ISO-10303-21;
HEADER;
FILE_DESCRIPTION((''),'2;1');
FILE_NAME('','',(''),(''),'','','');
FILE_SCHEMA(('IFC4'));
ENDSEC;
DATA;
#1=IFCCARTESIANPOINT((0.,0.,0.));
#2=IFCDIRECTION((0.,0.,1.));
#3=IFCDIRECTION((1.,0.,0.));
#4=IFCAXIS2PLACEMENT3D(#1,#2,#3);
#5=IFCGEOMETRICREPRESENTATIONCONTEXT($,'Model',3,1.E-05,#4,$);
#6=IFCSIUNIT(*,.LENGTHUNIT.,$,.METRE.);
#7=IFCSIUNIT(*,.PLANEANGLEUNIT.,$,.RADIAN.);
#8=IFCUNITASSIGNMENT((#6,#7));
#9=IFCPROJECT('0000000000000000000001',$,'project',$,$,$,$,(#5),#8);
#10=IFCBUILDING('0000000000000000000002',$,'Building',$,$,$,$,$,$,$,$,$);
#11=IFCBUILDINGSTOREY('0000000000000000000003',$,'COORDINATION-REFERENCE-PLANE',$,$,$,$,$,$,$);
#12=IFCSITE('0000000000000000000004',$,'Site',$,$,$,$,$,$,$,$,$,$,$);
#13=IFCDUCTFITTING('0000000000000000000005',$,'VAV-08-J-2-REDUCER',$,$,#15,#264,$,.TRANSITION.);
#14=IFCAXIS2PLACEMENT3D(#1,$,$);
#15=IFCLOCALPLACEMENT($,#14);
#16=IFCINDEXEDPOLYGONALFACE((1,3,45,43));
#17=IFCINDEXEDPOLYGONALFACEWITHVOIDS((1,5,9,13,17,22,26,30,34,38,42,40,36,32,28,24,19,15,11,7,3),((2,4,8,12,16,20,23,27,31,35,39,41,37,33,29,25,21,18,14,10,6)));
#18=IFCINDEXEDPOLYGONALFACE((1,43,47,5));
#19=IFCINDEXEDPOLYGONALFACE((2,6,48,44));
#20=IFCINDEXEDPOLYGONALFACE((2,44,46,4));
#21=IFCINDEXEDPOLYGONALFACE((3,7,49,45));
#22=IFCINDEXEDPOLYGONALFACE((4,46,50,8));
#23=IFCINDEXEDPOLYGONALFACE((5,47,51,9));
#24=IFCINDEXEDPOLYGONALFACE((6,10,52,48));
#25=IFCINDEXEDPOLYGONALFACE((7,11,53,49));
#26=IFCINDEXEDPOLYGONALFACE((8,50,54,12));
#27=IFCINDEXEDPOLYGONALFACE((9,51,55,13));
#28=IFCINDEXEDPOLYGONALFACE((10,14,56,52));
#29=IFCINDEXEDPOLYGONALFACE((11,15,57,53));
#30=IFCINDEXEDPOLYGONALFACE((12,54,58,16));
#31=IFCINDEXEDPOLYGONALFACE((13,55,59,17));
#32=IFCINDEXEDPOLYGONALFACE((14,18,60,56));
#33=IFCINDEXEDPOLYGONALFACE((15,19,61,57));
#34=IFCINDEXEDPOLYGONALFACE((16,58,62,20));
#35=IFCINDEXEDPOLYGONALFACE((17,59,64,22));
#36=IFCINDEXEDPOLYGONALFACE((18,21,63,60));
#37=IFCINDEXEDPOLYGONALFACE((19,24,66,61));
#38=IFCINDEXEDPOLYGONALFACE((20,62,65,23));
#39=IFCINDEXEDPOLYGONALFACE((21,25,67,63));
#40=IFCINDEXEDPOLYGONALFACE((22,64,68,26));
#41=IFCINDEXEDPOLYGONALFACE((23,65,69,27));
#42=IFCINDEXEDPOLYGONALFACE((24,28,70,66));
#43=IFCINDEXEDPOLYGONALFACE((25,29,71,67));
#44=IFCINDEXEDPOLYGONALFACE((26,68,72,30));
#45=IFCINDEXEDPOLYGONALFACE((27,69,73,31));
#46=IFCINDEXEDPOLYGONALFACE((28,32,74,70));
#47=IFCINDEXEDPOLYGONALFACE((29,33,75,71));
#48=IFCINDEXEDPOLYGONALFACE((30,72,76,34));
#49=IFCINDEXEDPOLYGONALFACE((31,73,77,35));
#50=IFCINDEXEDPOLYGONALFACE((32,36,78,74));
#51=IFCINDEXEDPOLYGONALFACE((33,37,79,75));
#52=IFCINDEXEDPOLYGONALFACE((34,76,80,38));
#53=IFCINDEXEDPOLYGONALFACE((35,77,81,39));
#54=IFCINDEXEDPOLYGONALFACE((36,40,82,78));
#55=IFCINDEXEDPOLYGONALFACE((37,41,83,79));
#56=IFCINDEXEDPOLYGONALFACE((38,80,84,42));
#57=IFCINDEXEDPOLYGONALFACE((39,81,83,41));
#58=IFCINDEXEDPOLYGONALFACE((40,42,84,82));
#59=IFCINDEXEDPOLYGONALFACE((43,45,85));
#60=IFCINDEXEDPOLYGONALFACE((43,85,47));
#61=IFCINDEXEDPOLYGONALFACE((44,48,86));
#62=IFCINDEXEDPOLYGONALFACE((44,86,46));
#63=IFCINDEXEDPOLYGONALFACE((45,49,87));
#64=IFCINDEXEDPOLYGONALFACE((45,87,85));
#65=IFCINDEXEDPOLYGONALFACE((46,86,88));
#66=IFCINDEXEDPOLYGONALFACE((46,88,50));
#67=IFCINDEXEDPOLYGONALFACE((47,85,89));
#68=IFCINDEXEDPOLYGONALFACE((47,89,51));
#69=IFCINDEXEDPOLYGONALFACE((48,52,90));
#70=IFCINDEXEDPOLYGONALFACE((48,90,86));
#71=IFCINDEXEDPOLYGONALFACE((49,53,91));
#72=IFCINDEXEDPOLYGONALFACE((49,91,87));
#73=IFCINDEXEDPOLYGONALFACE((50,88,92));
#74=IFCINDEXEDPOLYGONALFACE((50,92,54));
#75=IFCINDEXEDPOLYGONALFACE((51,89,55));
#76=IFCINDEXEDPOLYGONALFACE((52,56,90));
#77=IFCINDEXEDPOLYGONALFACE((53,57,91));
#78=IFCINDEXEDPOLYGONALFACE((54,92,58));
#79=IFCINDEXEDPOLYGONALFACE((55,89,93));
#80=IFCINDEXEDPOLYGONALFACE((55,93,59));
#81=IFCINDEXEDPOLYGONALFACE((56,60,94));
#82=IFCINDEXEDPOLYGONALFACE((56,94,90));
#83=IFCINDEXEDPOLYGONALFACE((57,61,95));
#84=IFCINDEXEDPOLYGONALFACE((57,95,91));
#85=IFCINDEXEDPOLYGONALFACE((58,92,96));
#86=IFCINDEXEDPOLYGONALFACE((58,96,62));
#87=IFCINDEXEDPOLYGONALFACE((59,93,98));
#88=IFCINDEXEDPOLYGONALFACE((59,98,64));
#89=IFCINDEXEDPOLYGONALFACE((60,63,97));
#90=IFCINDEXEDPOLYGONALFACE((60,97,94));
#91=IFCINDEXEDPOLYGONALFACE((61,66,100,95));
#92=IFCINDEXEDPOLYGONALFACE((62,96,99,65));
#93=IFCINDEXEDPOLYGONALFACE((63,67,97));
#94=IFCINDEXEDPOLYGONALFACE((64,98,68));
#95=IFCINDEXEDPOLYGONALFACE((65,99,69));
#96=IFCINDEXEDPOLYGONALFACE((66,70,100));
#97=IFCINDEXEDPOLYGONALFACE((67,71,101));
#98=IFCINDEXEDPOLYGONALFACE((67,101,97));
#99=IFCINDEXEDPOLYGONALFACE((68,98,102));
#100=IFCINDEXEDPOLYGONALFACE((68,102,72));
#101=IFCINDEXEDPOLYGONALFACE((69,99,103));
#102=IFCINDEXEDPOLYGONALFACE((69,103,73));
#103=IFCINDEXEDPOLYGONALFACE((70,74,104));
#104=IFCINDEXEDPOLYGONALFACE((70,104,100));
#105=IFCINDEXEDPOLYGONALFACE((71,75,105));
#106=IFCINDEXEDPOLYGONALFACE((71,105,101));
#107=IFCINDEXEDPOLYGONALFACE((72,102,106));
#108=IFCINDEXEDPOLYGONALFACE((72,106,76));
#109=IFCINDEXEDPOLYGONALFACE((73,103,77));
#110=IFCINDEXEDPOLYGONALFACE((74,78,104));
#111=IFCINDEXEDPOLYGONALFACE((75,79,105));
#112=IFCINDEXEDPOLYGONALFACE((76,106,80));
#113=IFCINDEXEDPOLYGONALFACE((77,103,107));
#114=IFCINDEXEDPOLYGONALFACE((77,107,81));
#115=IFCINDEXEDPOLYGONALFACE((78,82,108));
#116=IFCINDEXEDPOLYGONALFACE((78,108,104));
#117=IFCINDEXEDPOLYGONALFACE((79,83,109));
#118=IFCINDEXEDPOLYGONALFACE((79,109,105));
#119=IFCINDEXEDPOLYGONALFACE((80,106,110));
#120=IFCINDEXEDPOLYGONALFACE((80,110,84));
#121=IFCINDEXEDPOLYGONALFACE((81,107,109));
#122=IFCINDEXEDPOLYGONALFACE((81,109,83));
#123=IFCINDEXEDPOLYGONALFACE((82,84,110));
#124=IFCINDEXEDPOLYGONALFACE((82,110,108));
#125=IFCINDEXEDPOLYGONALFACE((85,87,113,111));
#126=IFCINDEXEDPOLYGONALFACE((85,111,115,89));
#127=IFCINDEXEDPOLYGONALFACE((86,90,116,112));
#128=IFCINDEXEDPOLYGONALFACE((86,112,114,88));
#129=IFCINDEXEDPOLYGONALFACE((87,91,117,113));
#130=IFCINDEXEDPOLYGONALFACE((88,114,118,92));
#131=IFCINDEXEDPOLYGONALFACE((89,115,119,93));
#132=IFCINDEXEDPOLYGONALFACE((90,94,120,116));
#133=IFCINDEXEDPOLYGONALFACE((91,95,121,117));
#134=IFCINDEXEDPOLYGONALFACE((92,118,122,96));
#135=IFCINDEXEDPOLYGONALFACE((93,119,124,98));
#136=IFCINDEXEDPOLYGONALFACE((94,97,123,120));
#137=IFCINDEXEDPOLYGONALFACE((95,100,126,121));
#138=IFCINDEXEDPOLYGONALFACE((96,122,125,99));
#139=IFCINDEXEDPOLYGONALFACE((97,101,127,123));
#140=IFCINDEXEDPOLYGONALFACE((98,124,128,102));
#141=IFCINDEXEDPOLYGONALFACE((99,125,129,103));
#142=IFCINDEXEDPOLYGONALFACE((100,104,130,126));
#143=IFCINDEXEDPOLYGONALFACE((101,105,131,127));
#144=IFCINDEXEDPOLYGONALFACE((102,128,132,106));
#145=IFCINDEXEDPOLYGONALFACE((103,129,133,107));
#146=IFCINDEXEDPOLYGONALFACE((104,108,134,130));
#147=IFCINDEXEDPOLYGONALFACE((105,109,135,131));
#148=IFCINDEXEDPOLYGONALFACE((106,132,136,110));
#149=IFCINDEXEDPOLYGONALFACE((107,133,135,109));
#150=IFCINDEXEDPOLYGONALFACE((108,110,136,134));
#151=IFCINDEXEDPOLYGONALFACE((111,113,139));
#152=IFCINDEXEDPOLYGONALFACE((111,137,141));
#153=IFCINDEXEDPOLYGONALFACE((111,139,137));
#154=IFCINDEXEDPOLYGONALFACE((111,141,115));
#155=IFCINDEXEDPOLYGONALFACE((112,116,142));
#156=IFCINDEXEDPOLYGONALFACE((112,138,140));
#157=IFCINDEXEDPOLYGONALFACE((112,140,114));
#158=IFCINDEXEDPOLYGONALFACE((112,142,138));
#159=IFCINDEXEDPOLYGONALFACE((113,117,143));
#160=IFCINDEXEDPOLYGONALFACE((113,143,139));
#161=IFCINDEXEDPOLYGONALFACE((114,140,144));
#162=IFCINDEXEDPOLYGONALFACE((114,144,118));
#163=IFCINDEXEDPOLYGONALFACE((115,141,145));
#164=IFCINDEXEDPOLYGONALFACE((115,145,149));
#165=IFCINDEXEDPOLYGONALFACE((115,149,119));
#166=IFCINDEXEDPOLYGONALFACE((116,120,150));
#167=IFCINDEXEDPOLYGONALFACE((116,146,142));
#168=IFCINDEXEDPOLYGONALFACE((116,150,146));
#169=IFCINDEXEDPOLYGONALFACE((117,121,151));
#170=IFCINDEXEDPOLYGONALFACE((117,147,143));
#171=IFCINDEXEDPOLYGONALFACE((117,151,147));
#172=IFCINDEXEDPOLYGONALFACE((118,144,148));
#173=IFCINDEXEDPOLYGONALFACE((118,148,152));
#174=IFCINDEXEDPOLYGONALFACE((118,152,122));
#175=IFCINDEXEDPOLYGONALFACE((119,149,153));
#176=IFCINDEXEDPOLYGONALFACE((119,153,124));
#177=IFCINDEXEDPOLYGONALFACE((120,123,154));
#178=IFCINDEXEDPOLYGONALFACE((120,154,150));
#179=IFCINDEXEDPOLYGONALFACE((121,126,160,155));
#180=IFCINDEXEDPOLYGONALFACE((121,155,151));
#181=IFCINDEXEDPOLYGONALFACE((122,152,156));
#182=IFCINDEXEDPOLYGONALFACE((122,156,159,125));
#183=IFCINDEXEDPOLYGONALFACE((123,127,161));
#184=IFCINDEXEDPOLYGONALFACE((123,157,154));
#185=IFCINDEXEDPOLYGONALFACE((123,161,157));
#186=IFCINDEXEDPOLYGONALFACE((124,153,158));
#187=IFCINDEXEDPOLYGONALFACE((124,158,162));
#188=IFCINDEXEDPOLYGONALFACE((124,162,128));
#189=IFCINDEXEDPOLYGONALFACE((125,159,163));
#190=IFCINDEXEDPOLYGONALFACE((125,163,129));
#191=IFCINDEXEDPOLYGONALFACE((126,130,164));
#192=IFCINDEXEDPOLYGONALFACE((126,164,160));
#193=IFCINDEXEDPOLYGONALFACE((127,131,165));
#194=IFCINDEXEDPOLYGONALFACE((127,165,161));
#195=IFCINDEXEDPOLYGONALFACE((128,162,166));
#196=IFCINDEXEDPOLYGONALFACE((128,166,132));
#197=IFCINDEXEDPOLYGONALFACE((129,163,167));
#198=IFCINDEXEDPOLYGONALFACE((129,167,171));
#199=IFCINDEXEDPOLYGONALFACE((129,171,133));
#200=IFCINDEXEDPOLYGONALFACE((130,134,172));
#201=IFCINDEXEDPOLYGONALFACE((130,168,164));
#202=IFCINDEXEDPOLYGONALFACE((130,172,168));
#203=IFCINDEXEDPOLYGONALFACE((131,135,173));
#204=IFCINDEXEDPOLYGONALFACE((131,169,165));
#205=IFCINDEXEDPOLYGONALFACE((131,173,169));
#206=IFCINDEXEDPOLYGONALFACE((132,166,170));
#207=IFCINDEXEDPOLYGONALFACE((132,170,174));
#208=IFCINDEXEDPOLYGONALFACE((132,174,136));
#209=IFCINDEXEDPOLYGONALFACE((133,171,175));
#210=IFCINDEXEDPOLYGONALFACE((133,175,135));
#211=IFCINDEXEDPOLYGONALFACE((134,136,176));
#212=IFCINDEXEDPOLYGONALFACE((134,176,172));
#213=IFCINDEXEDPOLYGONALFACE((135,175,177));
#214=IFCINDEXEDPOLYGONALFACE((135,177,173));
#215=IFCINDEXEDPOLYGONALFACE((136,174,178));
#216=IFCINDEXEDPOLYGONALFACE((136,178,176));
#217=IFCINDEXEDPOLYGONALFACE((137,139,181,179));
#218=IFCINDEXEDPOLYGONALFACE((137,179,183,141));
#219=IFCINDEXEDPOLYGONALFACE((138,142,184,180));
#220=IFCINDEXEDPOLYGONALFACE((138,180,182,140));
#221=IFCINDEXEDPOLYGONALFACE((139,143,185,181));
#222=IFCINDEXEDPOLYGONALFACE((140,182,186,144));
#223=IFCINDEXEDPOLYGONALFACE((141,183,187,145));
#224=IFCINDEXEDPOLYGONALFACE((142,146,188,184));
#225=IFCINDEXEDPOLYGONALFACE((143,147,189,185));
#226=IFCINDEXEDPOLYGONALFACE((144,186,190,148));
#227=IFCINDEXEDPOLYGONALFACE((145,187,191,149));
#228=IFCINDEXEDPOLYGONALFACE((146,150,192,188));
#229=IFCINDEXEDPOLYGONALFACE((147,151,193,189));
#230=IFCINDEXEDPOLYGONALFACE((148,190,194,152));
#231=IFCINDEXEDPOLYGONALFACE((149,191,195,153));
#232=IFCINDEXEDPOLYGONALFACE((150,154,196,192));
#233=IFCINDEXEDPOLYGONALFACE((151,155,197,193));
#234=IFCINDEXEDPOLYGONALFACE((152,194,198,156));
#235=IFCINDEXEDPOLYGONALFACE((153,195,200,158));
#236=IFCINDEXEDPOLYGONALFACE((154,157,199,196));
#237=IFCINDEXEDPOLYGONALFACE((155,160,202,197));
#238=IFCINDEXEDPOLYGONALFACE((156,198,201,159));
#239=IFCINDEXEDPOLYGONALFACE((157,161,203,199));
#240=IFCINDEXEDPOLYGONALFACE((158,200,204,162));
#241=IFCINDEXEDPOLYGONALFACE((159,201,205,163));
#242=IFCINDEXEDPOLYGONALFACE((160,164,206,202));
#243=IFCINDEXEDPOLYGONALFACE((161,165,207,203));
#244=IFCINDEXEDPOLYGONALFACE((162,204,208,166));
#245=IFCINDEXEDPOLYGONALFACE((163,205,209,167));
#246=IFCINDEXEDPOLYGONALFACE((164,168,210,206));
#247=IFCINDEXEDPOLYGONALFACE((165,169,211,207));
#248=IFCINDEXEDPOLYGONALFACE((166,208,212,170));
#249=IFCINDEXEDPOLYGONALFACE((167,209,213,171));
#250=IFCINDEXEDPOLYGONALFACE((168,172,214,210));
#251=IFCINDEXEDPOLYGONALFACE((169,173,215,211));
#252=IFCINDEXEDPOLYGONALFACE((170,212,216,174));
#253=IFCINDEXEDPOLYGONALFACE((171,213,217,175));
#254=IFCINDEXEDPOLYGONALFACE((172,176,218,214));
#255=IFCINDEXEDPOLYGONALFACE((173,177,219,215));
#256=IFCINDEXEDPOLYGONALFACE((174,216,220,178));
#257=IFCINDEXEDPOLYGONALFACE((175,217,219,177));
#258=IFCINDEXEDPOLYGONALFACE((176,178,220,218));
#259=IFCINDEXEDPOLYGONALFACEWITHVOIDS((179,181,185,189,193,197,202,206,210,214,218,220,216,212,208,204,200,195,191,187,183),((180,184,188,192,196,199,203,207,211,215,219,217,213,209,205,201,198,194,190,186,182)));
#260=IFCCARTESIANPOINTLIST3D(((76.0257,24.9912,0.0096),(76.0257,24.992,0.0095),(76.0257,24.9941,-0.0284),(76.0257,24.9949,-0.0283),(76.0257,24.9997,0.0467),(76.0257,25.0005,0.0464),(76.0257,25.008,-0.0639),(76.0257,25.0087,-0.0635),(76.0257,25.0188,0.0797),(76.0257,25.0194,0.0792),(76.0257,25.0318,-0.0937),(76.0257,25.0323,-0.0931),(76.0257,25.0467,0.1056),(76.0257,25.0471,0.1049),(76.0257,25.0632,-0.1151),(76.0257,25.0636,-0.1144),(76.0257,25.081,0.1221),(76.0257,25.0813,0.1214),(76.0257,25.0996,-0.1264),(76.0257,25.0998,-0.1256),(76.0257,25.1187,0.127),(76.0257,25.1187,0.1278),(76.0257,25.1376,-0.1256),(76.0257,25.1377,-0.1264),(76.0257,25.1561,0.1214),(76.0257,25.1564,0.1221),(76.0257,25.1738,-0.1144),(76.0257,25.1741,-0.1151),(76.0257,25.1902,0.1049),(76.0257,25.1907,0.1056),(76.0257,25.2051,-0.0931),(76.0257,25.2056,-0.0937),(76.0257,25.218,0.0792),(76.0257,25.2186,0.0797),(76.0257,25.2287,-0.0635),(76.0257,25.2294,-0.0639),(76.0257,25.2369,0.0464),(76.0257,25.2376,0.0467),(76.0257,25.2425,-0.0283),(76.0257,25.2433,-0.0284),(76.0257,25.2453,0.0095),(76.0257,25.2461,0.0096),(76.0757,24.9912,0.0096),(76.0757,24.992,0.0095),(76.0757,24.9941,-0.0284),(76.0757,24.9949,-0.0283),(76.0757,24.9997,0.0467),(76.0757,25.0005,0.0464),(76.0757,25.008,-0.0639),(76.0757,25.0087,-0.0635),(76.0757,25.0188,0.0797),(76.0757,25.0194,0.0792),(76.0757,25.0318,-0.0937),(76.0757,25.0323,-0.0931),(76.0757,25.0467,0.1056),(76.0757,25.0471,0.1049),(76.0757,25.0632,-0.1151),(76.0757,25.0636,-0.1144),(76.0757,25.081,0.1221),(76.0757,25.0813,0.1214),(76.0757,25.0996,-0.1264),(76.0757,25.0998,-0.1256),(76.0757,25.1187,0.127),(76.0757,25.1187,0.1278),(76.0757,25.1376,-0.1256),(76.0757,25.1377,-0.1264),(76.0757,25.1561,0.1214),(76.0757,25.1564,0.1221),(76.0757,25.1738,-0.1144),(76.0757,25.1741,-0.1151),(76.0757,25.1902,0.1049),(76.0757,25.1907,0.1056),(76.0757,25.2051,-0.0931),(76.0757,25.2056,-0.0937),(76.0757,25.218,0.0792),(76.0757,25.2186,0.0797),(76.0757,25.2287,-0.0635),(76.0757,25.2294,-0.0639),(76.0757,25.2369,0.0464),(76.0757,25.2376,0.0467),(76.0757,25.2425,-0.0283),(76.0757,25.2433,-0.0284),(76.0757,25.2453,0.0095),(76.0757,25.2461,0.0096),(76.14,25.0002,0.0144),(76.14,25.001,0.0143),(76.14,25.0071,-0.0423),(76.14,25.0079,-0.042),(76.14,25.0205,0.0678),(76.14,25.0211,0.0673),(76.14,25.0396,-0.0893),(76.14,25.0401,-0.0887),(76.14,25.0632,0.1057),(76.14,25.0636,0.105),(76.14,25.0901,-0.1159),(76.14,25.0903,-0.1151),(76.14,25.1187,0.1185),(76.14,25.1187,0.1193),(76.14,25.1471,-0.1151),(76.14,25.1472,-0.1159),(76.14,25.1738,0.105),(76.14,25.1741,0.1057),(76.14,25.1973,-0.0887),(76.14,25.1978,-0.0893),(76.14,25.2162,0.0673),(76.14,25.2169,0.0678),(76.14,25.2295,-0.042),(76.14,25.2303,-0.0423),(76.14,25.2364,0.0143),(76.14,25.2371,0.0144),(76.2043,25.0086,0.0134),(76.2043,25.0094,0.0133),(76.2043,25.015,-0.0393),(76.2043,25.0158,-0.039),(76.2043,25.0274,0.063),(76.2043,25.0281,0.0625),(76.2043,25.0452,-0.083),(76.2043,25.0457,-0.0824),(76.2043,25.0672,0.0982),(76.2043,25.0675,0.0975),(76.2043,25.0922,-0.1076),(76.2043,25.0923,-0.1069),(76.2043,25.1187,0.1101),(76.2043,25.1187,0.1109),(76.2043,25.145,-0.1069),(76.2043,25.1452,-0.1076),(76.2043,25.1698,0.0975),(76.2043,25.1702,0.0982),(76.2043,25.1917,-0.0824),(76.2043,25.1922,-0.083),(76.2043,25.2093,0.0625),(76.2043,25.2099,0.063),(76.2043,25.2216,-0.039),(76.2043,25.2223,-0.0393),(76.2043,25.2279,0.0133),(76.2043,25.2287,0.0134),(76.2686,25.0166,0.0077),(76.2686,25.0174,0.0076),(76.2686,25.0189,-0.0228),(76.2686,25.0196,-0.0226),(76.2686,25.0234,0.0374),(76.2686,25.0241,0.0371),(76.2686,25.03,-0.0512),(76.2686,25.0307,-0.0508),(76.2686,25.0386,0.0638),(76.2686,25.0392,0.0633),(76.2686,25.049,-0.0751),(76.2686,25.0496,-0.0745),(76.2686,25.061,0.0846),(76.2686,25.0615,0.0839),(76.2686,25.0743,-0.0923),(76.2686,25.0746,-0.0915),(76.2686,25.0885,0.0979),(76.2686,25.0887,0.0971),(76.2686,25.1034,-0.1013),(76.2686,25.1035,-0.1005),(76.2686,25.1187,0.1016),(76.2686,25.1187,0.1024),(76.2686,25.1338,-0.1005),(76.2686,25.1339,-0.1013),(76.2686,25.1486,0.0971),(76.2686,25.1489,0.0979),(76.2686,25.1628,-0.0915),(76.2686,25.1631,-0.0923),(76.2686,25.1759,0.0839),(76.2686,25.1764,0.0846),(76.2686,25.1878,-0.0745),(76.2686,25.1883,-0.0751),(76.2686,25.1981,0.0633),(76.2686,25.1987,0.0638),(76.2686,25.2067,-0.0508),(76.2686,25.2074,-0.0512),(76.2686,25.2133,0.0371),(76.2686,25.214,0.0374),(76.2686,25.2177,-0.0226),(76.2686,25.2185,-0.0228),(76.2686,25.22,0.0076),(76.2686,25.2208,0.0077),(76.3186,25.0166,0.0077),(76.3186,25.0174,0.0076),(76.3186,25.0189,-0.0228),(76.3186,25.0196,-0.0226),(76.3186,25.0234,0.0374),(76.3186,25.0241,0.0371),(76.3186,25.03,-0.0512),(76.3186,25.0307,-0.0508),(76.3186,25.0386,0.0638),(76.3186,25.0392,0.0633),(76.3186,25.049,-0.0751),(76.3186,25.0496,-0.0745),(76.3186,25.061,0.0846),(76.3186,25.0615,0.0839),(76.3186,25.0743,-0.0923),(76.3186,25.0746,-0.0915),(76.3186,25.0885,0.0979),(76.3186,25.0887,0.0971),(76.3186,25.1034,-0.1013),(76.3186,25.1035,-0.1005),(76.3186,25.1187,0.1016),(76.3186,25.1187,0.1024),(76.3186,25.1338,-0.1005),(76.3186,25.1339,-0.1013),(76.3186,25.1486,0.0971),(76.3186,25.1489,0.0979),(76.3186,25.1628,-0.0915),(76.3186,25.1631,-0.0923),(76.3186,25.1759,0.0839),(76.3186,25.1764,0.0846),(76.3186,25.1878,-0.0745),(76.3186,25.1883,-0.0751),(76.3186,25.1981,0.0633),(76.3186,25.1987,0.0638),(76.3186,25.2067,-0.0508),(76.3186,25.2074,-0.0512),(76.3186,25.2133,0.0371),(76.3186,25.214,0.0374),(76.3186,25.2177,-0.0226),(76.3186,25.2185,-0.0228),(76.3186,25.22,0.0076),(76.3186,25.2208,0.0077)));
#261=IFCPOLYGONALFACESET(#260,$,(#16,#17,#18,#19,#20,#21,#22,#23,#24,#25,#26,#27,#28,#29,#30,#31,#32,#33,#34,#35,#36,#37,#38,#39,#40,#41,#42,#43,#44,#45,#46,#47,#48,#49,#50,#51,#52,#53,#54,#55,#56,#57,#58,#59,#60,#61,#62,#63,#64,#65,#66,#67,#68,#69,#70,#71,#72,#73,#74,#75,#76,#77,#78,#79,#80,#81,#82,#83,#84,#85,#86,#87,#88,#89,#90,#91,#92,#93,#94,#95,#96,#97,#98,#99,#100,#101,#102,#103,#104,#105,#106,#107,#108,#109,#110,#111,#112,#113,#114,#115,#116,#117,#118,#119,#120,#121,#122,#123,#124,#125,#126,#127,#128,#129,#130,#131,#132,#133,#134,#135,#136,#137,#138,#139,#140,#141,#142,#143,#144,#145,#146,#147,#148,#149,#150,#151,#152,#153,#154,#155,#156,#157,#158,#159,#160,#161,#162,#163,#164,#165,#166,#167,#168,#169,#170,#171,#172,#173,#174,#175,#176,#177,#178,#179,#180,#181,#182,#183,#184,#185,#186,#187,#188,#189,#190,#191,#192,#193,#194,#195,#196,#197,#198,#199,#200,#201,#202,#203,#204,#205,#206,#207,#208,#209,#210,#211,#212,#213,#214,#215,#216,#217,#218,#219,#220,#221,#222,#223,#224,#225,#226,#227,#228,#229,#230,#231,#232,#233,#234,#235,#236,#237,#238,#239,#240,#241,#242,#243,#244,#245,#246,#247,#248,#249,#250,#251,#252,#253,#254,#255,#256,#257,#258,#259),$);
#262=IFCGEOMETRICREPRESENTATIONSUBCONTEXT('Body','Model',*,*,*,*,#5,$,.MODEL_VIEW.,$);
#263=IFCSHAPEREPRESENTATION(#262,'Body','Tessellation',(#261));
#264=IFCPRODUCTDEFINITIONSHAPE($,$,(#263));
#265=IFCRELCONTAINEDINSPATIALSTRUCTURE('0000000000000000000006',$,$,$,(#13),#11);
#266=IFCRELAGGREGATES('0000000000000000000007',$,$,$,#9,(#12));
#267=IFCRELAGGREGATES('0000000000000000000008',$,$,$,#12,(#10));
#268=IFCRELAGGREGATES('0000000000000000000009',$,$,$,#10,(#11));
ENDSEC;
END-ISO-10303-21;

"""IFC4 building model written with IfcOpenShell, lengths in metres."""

from ifc_helpers import new_model, entity, si_unit, frame, origin_with_axes, place, context, subcontext, project, spatial, element, save


model = new_model("IFC4")

# Units and contexts
model_context = context("Model", 3, precision=1e-05, world=origin_with_axes())
body_context_1 = subcontext(model_context, "Body", "Model", "MODEL_VIEW")
ifc_project = project(units=[si_unit("LENGTHUNIT", "METRE"), si_unit("PLANEANGLEUNIT", "RADIAN")], contexts=[model_context])

# Site, building, storey
site = spatial("IfcSite", under=ifc_project, Name="Site")
building = spatial("IfcBuilding", under=site, Name="Building")
storey = spatial("IfcBuildingStorey", under=building, Name="COORDINATION-REFERENCE-PLANE")

# Duct fitting
for number, where, z_axis, x_axis, name in (
    (1, (76.0257, 25.1187, 0.0), (0.0, 1.0, 0.0), (0.0, 0.0, 1.0), "VAV-08-J-2-REDUCER"),
):
    element("IfcDuctFitting", number, at=place(None, frame(where, z_axis=z_axis, x_axis=x_axis)), inside=storey, Name=name, PredefinedType="TRANSITION", context=body_context_1, shape_type="SweptSolid", body=[
        entity("IfcRevolvedAreaSolid", entity("IfcArbitraryClosedProfileDef", "AREA", None, entity("IfcPolyline", [entity("IfcCartesianPoint", [0.1278, 0.0]), entity("IfcCartesianPoint", [0.1278, 0.05]), entity("IfcCartesianPoint", [0.1024, 0.2429]), entity("IfcCartesianPoint", [0.1024, 0.2929]), entity("IfcCartesianPoint", [0.1016, 0.2929]), entity("IfcCartesianPoint", [0.1016, 0.2429]), entity("IfcCartesianPoint", [0.127, 0.05]), entity("IfcCartesianPoint", [0.127, 0.0]), entity("IfcCartesianPoint", [0.1278, 0.0])])), entity("IfcAxis2Placement3D", entity("IfcCartesianPoint", [0.0, 0.0, 0.0])), entity("IfcAxis1Placement", entity("IfcCartesianPoint", [0.0, 0.0, 0.0]), entity("IfcDirection", [0.0, 1.0, 0.0])), 6.283185),
    ])

save(model, "model.ifc")
